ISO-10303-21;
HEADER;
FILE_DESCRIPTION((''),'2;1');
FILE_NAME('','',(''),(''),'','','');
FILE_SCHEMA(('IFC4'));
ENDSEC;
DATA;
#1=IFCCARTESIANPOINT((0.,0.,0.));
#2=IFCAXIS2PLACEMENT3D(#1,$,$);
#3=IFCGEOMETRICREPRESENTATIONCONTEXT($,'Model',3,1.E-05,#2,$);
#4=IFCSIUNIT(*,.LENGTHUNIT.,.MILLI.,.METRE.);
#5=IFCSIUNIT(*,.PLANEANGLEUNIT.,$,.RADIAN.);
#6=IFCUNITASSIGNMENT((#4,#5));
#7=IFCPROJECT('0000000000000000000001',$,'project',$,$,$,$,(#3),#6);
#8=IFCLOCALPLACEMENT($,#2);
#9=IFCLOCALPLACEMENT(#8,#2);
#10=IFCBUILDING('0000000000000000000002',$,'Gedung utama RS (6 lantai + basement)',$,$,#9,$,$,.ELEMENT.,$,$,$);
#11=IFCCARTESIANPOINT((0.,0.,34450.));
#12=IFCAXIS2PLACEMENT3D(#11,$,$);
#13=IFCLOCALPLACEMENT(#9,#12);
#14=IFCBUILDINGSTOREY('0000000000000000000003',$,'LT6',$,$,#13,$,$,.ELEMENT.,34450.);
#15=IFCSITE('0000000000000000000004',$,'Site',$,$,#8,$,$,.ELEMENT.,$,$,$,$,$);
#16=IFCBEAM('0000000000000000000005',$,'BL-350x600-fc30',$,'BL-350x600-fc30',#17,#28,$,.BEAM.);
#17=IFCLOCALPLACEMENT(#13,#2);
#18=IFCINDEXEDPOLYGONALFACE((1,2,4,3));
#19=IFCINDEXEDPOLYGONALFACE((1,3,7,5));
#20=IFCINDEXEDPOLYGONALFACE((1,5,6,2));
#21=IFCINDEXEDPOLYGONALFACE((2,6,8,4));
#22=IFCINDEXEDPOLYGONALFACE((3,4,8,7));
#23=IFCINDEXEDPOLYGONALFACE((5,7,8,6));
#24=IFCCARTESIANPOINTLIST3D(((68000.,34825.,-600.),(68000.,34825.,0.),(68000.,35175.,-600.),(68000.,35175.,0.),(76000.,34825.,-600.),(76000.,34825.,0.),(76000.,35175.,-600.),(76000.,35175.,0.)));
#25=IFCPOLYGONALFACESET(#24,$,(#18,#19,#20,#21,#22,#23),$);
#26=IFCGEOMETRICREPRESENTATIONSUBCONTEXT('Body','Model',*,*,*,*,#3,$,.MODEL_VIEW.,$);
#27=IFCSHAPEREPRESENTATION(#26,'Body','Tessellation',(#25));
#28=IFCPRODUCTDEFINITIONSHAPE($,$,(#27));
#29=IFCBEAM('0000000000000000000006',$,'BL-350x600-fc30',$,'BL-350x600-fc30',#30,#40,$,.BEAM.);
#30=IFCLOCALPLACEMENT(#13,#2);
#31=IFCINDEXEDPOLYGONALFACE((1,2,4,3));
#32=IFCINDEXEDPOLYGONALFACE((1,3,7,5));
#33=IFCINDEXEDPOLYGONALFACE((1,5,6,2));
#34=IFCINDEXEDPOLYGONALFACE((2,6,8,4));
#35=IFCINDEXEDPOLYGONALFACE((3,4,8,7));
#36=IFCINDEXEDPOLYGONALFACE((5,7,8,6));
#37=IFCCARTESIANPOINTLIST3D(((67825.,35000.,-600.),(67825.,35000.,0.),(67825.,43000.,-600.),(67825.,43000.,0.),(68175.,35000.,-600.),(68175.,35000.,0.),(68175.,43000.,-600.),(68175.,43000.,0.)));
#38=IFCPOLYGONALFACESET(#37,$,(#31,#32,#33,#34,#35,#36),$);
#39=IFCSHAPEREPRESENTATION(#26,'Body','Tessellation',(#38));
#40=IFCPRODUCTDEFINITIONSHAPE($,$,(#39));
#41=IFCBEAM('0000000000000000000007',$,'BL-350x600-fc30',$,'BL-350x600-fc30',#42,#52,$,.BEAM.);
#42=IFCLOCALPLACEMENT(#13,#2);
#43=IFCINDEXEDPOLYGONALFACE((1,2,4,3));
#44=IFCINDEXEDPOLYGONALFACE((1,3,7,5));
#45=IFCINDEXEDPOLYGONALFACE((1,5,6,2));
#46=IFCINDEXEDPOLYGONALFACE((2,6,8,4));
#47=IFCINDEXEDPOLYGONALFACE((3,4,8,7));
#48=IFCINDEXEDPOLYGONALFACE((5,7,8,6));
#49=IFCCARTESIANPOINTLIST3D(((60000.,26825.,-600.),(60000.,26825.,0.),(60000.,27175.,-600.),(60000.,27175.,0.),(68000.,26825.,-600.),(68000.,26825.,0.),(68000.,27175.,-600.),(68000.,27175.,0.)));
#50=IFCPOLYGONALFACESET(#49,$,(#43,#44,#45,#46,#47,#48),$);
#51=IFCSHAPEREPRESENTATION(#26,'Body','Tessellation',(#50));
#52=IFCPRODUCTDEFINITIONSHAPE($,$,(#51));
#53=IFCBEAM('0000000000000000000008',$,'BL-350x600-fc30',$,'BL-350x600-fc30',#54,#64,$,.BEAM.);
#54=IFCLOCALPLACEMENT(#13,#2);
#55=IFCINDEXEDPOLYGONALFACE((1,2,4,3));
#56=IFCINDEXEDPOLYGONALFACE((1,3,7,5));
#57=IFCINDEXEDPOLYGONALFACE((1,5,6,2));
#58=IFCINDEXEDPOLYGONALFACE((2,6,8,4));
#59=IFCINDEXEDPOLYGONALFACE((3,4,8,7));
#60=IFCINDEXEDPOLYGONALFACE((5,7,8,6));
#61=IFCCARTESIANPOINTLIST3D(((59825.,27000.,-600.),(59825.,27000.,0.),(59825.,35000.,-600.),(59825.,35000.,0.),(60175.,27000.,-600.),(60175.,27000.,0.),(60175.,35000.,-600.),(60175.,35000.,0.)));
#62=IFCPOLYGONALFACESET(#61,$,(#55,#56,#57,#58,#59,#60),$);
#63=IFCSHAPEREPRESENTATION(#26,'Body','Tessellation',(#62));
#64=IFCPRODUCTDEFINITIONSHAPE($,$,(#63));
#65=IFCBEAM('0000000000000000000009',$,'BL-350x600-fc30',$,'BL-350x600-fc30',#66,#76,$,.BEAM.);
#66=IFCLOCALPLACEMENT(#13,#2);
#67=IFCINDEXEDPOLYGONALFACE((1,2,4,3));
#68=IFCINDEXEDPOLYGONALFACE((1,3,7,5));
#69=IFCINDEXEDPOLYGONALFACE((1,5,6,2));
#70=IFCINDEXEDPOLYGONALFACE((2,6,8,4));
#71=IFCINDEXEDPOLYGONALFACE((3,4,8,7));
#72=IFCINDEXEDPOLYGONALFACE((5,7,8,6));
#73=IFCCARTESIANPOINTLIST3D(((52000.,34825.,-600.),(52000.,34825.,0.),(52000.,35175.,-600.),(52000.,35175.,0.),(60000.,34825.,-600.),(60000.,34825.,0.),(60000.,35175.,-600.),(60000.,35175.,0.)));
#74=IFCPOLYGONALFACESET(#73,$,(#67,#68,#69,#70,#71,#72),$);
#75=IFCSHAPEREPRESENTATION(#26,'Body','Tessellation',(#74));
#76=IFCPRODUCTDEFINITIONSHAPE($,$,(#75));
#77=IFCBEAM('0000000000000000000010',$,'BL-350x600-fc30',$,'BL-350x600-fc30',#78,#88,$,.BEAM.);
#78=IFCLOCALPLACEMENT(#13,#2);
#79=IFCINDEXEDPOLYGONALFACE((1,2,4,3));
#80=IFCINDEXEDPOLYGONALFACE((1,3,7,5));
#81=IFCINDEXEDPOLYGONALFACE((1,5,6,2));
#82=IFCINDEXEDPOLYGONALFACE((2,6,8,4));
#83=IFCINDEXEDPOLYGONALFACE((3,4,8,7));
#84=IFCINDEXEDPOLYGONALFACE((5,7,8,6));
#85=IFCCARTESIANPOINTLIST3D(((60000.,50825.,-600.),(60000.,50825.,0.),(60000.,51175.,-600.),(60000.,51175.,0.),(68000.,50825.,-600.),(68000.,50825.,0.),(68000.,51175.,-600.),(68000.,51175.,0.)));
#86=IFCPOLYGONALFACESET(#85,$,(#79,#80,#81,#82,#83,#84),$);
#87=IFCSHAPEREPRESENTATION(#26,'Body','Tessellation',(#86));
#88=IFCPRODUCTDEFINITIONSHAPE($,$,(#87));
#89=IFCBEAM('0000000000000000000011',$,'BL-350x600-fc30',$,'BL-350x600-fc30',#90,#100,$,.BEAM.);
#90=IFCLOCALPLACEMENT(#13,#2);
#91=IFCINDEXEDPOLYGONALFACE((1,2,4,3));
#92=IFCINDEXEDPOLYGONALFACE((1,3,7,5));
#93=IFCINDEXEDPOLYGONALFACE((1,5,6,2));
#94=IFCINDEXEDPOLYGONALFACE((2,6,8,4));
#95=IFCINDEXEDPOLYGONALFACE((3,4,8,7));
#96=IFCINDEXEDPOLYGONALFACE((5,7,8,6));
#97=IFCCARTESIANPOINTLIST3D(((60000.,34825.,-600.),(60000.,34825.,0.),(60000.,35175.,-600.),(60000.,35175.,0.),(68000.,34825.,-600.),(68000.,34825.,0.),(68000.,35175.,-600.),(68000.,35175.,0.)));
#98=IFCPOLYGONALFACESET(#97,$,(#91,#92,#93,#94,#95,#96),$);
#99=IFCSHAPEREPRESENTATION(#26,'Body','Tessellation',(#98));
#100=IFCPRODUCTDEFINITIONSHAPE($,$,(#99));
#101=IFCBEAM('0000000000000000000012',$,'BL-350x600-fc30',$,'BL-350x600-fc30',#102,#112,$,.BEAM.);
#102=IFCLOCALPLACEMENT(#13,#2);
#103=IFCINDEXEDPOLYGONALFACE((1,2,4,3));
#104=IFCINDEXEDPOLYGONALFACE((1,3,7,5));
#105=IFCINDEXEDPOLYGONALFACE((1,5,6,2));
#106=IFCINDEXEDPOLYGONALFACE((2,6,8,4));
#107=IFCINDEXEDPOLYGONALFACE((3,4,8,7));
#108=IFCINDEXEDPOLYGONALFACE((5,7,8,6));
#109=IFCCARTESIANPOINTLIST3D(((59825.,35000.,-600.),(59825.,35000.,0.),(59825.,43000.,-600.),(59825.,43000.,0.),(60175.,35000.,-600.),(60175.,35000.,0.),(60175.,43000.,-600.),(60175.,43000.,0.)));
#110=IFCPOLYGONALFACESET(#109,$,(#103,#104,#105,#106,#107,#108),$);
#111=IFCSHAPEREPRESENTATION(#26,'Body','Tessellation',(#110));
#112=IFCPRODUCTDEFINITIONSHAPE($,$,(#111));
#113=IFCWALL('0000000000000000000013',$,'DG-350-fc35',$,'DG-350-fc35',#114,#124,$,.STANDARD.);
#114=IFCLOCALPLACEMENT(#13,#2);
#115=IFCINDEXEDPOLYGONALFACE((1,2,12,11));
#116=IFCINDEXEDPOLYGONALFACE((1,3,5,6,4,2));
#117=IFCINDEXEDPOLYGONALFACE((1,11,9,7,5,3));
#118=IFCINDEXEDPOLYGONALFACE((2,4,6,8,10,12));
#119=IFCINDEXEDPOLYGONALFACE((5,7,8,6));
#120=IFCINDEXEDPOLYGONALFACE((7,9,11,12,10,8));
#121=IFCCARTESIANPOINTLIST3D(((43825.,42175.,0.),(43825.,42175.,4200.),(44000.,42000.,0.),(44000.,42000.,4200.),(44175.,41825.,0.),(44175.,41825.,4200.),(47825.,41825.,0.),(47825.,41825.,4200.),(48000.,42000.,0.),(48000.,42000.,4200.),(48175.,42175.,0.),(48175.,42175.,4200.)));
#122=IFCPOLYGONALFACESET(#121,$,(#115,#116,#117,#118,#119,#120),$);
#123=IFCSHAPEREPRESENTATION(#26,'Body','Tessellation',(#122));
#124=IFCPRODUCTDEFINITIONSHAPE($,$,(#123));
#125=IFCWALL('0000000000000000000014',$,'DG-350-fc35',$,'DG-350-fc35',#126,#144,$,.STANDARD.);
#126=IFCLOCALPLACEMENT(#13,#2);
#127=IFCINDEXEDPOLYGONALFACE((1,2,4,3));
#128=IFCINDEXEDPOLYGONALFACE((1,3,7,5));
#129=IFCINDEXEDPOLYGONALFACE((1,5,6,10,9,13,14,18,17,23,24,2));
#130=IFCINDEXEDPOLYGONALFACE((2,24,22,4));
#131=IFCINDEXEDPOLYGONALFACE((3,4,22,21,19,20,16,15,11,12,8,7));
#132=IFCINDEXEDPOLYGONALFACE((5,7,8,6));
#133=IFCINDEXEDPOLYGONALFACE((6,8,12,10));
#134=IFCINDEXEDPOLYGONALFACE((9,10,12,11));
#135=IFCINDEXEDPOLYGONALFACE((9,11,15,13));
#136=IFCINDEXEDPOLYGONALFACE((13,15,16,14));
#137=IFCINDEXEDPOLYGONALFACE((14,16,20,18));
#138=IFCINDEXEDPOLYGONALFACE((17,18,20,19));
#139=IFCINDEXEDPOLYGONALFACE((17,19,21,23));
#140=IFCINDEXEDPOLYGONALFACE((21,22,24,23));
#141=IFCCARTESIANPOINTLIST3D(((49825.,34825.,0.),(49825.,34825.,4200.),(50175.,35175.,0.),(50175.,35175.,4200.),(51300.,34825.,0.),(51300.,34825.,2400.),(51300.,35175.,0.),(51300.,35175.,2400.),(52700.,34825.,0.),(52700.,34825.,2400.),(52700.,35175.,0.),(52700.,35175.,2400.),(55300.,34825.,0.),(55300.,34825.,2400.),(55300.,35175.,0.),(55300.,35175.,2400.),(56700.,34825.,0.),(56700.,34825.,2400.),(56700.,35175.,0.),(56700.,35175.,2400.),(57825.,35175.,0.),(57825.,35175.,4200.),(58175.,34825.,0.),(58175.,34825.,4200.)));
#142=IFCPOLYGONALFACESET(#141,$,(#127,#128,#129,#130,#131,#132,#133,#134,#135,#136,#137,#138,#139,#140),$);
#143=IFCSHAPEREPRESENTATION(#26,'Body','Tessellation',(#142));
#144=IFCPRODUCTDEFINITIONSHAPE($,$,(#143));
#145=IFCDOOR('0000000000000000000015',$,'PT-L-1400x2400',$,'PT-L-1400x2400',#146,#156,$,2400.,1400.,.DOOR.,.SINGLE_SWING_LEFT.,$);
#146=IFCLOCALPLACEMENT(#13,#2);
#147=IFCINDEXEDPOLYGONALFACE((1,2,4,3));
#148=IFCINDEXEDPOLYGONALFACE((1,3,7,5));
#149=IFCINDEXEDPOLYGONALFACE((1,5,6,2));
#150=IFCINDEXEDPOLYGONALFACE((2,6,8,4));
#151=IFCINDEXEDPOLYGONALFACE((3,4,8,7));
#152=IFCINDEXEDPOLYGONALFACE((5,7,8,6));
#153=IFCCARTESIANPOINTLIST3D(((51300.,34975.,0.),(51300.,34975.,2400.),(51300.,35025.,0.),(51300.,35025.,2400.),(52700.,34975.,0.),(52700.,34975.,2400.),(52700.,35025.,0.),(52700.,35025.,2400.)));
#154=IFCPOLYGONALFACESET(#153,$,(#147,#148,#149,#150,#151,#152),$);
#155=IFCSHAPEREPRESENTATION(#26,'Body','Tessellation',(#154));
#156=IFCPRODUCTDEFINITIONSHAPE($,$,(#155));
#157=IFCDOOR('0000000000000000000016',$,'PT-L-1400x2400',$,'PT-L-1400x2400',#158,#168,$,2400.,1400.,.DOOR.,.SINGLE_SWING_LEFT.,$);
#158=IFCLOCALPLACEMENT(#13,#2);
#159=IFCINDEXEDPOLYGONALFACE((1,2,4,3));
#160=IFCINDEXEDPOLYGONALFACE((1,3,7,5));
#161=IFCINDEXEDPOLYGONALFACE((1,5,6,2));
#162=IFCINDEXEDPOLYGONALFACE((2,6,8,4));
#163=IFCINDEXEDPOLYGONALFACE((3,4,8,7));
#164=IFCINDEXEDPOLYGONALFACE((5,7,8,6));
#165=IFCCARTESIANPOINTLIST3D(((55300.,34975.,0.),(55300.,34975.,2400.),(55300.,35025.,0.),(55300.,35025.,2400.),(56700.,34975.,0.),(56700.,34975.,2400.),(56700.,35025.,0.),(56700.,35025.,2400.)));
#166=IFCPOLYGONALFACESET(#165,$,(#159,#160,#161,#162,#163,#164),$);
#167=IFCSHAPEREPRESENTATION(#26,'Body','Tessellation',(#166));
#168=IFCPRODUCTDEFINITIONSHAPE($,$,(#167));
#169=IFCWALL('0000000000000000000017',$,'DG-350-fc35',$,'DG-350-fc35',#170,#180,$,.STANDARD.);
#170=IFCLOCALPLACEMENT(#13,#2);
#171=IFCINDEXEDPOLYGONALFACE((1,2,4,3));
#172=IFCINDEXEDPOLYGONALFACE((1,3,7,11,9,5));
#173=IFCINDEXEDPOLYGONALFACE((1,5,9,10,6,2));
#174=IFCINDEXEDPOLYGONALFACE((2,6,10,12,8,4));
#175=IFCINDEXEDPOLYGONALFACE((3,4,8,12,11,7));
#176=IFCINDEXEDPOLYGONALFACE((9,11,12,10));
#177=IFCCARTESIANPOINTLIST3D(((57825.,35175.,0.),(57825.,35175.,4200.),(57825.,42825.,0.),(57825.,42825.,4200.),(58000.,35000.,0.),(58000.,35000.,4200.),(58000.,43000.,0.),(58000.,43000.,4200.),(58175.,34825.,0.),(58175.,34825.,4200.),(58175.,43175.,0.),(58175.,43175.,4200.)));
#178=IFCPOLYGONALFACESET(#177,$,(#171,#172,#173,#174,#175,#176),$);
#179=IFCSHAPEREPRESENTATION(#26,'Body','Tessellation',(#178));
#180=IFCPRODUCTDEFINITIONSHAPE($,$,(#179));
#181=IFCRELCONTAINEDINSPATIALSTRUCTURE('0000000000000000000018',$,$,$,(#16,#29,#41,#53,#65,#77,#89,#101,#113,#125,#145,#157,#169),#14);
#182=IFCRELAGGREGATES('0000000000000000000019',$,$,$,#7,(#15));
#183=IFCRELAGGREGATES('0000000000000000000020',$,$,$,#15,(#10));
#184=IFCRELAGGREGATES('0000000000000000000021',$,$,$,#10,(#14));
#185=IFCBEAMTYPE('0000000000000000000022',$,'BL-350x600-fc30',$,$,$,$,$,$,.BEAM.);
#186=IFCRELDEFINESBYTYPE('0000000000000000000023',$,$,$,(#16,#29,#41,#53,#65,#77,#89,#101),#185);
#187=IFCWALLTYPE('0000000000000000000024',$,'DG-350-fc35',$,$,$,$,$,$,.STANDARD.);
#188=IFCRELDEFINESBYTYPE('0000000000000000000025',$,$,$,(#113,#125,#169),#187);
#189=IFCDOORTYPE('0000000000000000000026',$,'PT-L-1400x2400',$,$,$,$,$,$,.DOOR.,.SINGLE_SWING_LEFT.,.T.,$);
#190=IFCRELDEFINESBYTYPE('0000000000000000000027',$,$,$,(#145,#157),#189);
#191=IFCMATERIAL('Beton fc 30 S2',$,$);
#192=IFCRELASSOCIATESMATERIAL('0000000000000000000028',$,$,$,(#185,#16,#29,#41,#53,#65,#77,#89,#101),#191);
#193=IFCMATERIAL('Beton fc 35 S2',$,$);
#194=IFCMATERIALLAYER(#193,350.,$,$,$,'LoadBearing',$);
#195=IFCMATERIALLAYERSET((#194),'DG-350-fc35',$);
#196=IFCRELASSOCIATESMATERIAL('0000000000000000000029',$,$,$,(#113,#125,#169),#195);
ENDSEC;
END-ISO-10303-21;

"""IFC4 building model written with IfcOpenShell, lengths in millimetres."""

from ifc_helpers import new_model, si_unit, frame, frame_2d, origin, origin_2d, place, context, subcontext, project, spatial, polyline, rectangle, outline, extrude, material, layer, layer_set, layer_usage, material_profile, profile_set, profile_usage, type_object, element, fill, save


model = new_model("IFC4")

# Units and contexts
model_context = context("Model", 3, precision=1e-05, world=origin())
body_context = subcontext(model_context, "Body", "Model", "MODEL_VIEW")
ifc_project = project(units=[si_unit("LENGTHUNIT", "METRE", prefix="MILLI"), si_unit("PLANEANGLEUNIT", "RADIAN")], contexts=[model_context])

# Site, building, storey
site_placement = place(None, origin())
site = spatial("IfcSite", under=ifc_project, at=site_placement, Name="Site", CompositionType="ELEMENT")
building_placement = place(site_placement, origin())
building = spatial("IfcBuilding", under=site, at=building_placement, Name="Gedung utama RS (6 lantai + basement)", CompositionType="ELEMENT")
storey_placement = place(building_placement, frame((0.0, 0.0, 34450.0)))
storey = spatial("IfcBuildingStorey", under=building, at=storey_placement, Name="LT6", CompositionType="ELEMENT", Elevation=34450.0)

# Beams
ifc_material_1 = material(Name="Beton fc 30 S2")
ifc_material_profile_1 = material_profile(ifc_material_1, rectangle(XDim=350.0, YDim=600.0, at=origin_2d()), Name="BL-350x600-fc30")
ifc_profile_set_1 = profile_set([ifc_material_profile_1], Name="BL-350x600-fc30")
ifc_profile_usage_1 = profile_usage(ifc_profile_set_1, cardinal=8)
beam_type = type_object("IfcBeamType", Name="BL-350x600-fc30", PredefinedType="BEAM", material=ifc_profile_set_1)
for number, where, name in (
    (1, (68000.0, 35000.0, -300.0), "BL-350x600-fc30"),
):
    element("IfcBeam", number, at=place(storey_placement, frame(where)), inside=storey, type_object=beam_type, material=ifc_profile_usage_1, Name=name, ObjectType="BL-350x600-fc30", PredefinedType="BEAM", context=body_context, shape_type="SweptSolid", body=[
        extrude(rectangle(XDim=350.0, YDim=600.0, at=origin_2d()), frame((0.0, 0.0, 0.0), z_axis=(1.0, 0.0, 0.0), x_axis=(0.0, 1.0, 0.0)), (0.0, 0.0, 1.0), 8000.0),
    ])
beam_1_placement = place(storey_placement, frame((68000.0, 35000.0, -300.0)))
element("IfcBeam", 2, at=beam_1_placement, inside=storey, type_object=beam_type, material=ifc_profile_usage_1, Name="BL-350x600-fc30", ObjectType="BL-350x600-fc30", PredefinedType="BEAM", context=body_context, shape_type="SweptSolid", body=[
    extrude(rectangle(XDim=350.0, YDim=600.0, at=origin_2d()), frame((0.0, 0.0, 0.0), z_axis=(0.0, 1.0, 0.0), x_axis=(-1.0, 0.0, 0.0)), (0.0, 0.0, 1.0), 8000.0),
])
beam_2_placement = place(storey_placement, frame((60000.0, 27000.0, -300.0)))
element("IfcBeam", 3, at=beam_2_placement, inside=storey, type_object=beam_type, material=ifc_profile_usage_1, Name="BL-350x600-fc30", ObjectType="BL-350x600-fc30", PredefinedType="BEAM", context=body_context, shape_type="SweptSolid", body=[
    extrude(rectangle(XDim=350.0, YDim=600.0, at=origin_2d()), frame((0.0, 0.0, 0.0), z_axis=(1.0, 0.0, 0.0), x_axis=(0.0, 1.0, 0.0)), (0.0, 0.0, 1.0), 8000.0),
])
beam_3_placement = place(storey_placement, frame((60000.0, 27000.0, -300.0)))
element("IfcBeam", 4, at=beam_3_placement, inside=storey, type_object=beam_type, material=ifc_profile_usage_1, Name="BL-350x600-fc30", ObjectType="BL-350x600-fc30", PredefinedType="BEAM", context=body_context, shape_type="SweptSolid", body=[
    extrude(rectangle(XDim=350.0, YDim=600.0, at=origin_2d()), frame((0.0, 0.0, 0.0), z_axis=(0.0, 1.0, 0.0), x_axis=(-1.0, 0.0, 0.0)), (0.0, 0.0, 1.0), 8000.0),
])
for number, where, name in (
    (5, (52000.0, 35000.0, -300.0), "BL-350x600-fc30"),
    (6, (60000.0, 51000.0, -300.0), "BL-350x600-fc30"),
    (7, (60000.0, 35000.0, -300.0), "BL-350x600-fc30"),
):
    element("IfcBeam", number, at=place(storey_placement, frame(where)), inside=storey, type_object=beam_type, material=ifc_profile_usage_1, Name=name, ObjectType="BL-350x600-fc30", PredefinedType="BEAM", context=body_context, shape_type="SweptSolid", body=[
        extrude(rectangle(XDim=350.0, YDim=600.0, at=origin_2d()), frame((0.0, 0.0, 0.0), z_axis=(1.0, 0.0, 0.0), x_axis=(0.0, 1.0, 0.0)), (0.0, 0.0, 1.0), 8000.0),
    ])
beam_4_placement = place(storey_placement, frame((60000.0, 35000.0, -300.0)))
element("IfcBeam", 8, at=beam_4_placement, inside=storey, type_object=beam_type, material=ifc_profile_usage_1, Name="BL-350x600-fc30", ObjectType="BL-350x600-fc30", PredefinedType="BEAM", context=body_context, shape_type="SweptSolid", body=[
    extrude(rectangle(XDim=350.0, YDim=600.0, at=origin_2d()), frame((0.0, 0.0, 0.0), z_axis=(0.0, 1.0, 0.0), x_axis=(-1.0, 0.0, 0.0)), (0.0, 0.0, 1.0), 8000.0),
])

# Wall
ifc_material_2 = material(Name="Beton fc 35 S2")
ifc_layer = layer(ifc_material_2, 350.0, Category="LoadBearing")
ifc_layer_set = layer_set([ifc_layer], Name="DG-350-fc35")
ifc_layer_usage = layer_usage(ifc_layer_set, "AXIS2", "NEGATIVE", 175.0)
wall_type = type_object("IfcWallType", Name="DG-350-fc35", PredefinedType="STANDARD")
wall_1_placement = place(storey_placement, frame((48000.0, 42000.0, 0.0), z_axis=(0.0, 0.0, 1.0), x_axis=(-1.0, 0.0, 0.0)))
element("IfcWall", 9, at=wall_1_placement, inside=storey, type_object=wall_type, material=ifc_layer_usage, Name="DG-350-fc35", ObjectType="DG-350-fc35", PredefinedType="STANDARD", context=body_context, shape_type="SweptSolid", body=[
    extrude(outline(polyline([(-175.0, -175.0), (0.0, 0.0), (175.0, 175.0), (3825.0, 175.0), (4000.0, 0.0), (4175.0, -175.0), (-175.0, -175.0)])), origin(), (0.0, 0.0, 1.0), 4200.0),
])

# Wall, openings, doors
wall_2_placement = place(storey_placement, frame((50000.0, 35000.0, 0.0), z_axis=(0.0, 0.0, 1.0), x_axis=(1.0, 0.0, 0.0)))
wall_2 = element("IfcWall", 10, at=wall_2_placement, inside=storey, type_object=wall_type, material=ifc_layer_usage, Name="DG-350-fc35", ObjectType="DG-350-fc35", PredefinedType="STANDARD", context=body_context, shape_type="SweptSolid", body=[
    extrude(outline(polyline([(-175.0, -175.0), (0.0, 0.0), (175.0, 175.0), (7825.0, 175.0), (8000.0, 0.0), (8175.0, -175.0), (-175.0, -175.0)])), origin(), (0.0, 0.0, 1.0), 4200.0),
])
opening_1_placement = place(wall_2_placement, frame((1300.0, 0.0, 0.0), z_axis=(0.0, 0.0, 1.0), x_axis=(1.0, 0.0, 0.0)))
opening_1 = element("IfcOpeningElement", 11, at=opening_1_placement, cuts=wall_2, PredefinedType="OPENING", context=body_context, shape_type="SweptSolid", body=[
    extrude(rectangle(XDim=1400.0, YDim=370.0, at=frame_2d((700.0, 0.0))), origin(), (0.0, 0.0, 1.0), 2400.0),
])
opening_2_placement = place(wall_2_placement, frame((5300.0, 0.0, 0.0), z_axis=(0.0, 0.0, 1.0), x_axis=(1.0, 0.0, 0.0)))
opening_2 = element("IfcOpeningElement", 12, at=opening_2_placement, cuts=wall_2, PredefinedType="OPENING", context=body_context, shape_type="SweptSolid", body=[
    extrude(rectangle(XDim=1400.0, YDim=370.0, at=frame_2d((700.0, 0.0))), origin(), (0.0, 0.0, 1.0), 2400.0),
])
door_type = type_object("IfcDoorType", Name="PT-L-1400x2400", OperationType="SINGLE_SWING_LEFT", ParameterTakesPrecedence=True, PredefinedType="DOOR")
door_1_placement = place(opening_1_placement, origin())
door_1 = element("IfcDoor", 13, at=door_1_placement, inside=storey, type_object=door_type, Name="PT-L-1400x2400", ObjectType="PT-L-1400x2400", OperationType="SINGLE_SWING_LEFT", OverallHeight=2400.0, OverallWidth=1400.0, PredefinedType="DOOR", context=body_context, shape_type="SweptSolid", body=[
    extrude(rectangle(XDim=1400.0, YDim=50.0, at=frame_2d((700.0, 0.0))), origin(), (0.0, 0.0, 1.0), 2400.0),
])
fill(opening_1, door_1)
door_2_placement = place(opening_2_placement, origin())
door_2 = element("IfcDoor", 14, at=door_2_placement, inside=storey, type_object=door_type, Name="PT-L-1400x2400", ObjectType="PT-L-1400x2400", OperationType="SINGLE_SWING_LEFT", OverallHeight=2400.0, OverallWidth=1400.0, PredefinedType="DOOR", context=body_context, shape_type="SweptSolid", body=[
    extrude(rectangle(XDim=1400.0, YDim=50.0, at=frame_2d((700.0, 0.0))), origin(), (0.0, 0.0, 1.0), 2400.0),
])
fill(opening_2, door_2)

# Wall
for number, where, z_axis, x_axis, name in (
    (15, (58000.0, 35000.0, 0.0), (0.0, 0.0, 1.0), (0.0, 1.0, 0.0), "DG-350-fc35"),
):
    element("IfcWall", number, at=place(storey_placement, frame(where, z_axis=z_axis, x_axis=x_axis)), inside=storey, type_object=wall_type, material=ifc_layer_usage, Name=name, ObjectType="DG-350-fc35", PredefinedType="STANDARD", context=body_context, shape_type="SweptSolid", body=[
        extrude(outline(polyline([(-175.0, -175.0), (0.0, 0.0), (175.0, 175.0), (7825.0, 175.0), (8000.0, 0.0), (8175.0, -175.0), (-175.0, -175.0)])), origin(), (0.0, 0.0, 1.0), 4200.0),
    ])

save(model, "model.ifc")
